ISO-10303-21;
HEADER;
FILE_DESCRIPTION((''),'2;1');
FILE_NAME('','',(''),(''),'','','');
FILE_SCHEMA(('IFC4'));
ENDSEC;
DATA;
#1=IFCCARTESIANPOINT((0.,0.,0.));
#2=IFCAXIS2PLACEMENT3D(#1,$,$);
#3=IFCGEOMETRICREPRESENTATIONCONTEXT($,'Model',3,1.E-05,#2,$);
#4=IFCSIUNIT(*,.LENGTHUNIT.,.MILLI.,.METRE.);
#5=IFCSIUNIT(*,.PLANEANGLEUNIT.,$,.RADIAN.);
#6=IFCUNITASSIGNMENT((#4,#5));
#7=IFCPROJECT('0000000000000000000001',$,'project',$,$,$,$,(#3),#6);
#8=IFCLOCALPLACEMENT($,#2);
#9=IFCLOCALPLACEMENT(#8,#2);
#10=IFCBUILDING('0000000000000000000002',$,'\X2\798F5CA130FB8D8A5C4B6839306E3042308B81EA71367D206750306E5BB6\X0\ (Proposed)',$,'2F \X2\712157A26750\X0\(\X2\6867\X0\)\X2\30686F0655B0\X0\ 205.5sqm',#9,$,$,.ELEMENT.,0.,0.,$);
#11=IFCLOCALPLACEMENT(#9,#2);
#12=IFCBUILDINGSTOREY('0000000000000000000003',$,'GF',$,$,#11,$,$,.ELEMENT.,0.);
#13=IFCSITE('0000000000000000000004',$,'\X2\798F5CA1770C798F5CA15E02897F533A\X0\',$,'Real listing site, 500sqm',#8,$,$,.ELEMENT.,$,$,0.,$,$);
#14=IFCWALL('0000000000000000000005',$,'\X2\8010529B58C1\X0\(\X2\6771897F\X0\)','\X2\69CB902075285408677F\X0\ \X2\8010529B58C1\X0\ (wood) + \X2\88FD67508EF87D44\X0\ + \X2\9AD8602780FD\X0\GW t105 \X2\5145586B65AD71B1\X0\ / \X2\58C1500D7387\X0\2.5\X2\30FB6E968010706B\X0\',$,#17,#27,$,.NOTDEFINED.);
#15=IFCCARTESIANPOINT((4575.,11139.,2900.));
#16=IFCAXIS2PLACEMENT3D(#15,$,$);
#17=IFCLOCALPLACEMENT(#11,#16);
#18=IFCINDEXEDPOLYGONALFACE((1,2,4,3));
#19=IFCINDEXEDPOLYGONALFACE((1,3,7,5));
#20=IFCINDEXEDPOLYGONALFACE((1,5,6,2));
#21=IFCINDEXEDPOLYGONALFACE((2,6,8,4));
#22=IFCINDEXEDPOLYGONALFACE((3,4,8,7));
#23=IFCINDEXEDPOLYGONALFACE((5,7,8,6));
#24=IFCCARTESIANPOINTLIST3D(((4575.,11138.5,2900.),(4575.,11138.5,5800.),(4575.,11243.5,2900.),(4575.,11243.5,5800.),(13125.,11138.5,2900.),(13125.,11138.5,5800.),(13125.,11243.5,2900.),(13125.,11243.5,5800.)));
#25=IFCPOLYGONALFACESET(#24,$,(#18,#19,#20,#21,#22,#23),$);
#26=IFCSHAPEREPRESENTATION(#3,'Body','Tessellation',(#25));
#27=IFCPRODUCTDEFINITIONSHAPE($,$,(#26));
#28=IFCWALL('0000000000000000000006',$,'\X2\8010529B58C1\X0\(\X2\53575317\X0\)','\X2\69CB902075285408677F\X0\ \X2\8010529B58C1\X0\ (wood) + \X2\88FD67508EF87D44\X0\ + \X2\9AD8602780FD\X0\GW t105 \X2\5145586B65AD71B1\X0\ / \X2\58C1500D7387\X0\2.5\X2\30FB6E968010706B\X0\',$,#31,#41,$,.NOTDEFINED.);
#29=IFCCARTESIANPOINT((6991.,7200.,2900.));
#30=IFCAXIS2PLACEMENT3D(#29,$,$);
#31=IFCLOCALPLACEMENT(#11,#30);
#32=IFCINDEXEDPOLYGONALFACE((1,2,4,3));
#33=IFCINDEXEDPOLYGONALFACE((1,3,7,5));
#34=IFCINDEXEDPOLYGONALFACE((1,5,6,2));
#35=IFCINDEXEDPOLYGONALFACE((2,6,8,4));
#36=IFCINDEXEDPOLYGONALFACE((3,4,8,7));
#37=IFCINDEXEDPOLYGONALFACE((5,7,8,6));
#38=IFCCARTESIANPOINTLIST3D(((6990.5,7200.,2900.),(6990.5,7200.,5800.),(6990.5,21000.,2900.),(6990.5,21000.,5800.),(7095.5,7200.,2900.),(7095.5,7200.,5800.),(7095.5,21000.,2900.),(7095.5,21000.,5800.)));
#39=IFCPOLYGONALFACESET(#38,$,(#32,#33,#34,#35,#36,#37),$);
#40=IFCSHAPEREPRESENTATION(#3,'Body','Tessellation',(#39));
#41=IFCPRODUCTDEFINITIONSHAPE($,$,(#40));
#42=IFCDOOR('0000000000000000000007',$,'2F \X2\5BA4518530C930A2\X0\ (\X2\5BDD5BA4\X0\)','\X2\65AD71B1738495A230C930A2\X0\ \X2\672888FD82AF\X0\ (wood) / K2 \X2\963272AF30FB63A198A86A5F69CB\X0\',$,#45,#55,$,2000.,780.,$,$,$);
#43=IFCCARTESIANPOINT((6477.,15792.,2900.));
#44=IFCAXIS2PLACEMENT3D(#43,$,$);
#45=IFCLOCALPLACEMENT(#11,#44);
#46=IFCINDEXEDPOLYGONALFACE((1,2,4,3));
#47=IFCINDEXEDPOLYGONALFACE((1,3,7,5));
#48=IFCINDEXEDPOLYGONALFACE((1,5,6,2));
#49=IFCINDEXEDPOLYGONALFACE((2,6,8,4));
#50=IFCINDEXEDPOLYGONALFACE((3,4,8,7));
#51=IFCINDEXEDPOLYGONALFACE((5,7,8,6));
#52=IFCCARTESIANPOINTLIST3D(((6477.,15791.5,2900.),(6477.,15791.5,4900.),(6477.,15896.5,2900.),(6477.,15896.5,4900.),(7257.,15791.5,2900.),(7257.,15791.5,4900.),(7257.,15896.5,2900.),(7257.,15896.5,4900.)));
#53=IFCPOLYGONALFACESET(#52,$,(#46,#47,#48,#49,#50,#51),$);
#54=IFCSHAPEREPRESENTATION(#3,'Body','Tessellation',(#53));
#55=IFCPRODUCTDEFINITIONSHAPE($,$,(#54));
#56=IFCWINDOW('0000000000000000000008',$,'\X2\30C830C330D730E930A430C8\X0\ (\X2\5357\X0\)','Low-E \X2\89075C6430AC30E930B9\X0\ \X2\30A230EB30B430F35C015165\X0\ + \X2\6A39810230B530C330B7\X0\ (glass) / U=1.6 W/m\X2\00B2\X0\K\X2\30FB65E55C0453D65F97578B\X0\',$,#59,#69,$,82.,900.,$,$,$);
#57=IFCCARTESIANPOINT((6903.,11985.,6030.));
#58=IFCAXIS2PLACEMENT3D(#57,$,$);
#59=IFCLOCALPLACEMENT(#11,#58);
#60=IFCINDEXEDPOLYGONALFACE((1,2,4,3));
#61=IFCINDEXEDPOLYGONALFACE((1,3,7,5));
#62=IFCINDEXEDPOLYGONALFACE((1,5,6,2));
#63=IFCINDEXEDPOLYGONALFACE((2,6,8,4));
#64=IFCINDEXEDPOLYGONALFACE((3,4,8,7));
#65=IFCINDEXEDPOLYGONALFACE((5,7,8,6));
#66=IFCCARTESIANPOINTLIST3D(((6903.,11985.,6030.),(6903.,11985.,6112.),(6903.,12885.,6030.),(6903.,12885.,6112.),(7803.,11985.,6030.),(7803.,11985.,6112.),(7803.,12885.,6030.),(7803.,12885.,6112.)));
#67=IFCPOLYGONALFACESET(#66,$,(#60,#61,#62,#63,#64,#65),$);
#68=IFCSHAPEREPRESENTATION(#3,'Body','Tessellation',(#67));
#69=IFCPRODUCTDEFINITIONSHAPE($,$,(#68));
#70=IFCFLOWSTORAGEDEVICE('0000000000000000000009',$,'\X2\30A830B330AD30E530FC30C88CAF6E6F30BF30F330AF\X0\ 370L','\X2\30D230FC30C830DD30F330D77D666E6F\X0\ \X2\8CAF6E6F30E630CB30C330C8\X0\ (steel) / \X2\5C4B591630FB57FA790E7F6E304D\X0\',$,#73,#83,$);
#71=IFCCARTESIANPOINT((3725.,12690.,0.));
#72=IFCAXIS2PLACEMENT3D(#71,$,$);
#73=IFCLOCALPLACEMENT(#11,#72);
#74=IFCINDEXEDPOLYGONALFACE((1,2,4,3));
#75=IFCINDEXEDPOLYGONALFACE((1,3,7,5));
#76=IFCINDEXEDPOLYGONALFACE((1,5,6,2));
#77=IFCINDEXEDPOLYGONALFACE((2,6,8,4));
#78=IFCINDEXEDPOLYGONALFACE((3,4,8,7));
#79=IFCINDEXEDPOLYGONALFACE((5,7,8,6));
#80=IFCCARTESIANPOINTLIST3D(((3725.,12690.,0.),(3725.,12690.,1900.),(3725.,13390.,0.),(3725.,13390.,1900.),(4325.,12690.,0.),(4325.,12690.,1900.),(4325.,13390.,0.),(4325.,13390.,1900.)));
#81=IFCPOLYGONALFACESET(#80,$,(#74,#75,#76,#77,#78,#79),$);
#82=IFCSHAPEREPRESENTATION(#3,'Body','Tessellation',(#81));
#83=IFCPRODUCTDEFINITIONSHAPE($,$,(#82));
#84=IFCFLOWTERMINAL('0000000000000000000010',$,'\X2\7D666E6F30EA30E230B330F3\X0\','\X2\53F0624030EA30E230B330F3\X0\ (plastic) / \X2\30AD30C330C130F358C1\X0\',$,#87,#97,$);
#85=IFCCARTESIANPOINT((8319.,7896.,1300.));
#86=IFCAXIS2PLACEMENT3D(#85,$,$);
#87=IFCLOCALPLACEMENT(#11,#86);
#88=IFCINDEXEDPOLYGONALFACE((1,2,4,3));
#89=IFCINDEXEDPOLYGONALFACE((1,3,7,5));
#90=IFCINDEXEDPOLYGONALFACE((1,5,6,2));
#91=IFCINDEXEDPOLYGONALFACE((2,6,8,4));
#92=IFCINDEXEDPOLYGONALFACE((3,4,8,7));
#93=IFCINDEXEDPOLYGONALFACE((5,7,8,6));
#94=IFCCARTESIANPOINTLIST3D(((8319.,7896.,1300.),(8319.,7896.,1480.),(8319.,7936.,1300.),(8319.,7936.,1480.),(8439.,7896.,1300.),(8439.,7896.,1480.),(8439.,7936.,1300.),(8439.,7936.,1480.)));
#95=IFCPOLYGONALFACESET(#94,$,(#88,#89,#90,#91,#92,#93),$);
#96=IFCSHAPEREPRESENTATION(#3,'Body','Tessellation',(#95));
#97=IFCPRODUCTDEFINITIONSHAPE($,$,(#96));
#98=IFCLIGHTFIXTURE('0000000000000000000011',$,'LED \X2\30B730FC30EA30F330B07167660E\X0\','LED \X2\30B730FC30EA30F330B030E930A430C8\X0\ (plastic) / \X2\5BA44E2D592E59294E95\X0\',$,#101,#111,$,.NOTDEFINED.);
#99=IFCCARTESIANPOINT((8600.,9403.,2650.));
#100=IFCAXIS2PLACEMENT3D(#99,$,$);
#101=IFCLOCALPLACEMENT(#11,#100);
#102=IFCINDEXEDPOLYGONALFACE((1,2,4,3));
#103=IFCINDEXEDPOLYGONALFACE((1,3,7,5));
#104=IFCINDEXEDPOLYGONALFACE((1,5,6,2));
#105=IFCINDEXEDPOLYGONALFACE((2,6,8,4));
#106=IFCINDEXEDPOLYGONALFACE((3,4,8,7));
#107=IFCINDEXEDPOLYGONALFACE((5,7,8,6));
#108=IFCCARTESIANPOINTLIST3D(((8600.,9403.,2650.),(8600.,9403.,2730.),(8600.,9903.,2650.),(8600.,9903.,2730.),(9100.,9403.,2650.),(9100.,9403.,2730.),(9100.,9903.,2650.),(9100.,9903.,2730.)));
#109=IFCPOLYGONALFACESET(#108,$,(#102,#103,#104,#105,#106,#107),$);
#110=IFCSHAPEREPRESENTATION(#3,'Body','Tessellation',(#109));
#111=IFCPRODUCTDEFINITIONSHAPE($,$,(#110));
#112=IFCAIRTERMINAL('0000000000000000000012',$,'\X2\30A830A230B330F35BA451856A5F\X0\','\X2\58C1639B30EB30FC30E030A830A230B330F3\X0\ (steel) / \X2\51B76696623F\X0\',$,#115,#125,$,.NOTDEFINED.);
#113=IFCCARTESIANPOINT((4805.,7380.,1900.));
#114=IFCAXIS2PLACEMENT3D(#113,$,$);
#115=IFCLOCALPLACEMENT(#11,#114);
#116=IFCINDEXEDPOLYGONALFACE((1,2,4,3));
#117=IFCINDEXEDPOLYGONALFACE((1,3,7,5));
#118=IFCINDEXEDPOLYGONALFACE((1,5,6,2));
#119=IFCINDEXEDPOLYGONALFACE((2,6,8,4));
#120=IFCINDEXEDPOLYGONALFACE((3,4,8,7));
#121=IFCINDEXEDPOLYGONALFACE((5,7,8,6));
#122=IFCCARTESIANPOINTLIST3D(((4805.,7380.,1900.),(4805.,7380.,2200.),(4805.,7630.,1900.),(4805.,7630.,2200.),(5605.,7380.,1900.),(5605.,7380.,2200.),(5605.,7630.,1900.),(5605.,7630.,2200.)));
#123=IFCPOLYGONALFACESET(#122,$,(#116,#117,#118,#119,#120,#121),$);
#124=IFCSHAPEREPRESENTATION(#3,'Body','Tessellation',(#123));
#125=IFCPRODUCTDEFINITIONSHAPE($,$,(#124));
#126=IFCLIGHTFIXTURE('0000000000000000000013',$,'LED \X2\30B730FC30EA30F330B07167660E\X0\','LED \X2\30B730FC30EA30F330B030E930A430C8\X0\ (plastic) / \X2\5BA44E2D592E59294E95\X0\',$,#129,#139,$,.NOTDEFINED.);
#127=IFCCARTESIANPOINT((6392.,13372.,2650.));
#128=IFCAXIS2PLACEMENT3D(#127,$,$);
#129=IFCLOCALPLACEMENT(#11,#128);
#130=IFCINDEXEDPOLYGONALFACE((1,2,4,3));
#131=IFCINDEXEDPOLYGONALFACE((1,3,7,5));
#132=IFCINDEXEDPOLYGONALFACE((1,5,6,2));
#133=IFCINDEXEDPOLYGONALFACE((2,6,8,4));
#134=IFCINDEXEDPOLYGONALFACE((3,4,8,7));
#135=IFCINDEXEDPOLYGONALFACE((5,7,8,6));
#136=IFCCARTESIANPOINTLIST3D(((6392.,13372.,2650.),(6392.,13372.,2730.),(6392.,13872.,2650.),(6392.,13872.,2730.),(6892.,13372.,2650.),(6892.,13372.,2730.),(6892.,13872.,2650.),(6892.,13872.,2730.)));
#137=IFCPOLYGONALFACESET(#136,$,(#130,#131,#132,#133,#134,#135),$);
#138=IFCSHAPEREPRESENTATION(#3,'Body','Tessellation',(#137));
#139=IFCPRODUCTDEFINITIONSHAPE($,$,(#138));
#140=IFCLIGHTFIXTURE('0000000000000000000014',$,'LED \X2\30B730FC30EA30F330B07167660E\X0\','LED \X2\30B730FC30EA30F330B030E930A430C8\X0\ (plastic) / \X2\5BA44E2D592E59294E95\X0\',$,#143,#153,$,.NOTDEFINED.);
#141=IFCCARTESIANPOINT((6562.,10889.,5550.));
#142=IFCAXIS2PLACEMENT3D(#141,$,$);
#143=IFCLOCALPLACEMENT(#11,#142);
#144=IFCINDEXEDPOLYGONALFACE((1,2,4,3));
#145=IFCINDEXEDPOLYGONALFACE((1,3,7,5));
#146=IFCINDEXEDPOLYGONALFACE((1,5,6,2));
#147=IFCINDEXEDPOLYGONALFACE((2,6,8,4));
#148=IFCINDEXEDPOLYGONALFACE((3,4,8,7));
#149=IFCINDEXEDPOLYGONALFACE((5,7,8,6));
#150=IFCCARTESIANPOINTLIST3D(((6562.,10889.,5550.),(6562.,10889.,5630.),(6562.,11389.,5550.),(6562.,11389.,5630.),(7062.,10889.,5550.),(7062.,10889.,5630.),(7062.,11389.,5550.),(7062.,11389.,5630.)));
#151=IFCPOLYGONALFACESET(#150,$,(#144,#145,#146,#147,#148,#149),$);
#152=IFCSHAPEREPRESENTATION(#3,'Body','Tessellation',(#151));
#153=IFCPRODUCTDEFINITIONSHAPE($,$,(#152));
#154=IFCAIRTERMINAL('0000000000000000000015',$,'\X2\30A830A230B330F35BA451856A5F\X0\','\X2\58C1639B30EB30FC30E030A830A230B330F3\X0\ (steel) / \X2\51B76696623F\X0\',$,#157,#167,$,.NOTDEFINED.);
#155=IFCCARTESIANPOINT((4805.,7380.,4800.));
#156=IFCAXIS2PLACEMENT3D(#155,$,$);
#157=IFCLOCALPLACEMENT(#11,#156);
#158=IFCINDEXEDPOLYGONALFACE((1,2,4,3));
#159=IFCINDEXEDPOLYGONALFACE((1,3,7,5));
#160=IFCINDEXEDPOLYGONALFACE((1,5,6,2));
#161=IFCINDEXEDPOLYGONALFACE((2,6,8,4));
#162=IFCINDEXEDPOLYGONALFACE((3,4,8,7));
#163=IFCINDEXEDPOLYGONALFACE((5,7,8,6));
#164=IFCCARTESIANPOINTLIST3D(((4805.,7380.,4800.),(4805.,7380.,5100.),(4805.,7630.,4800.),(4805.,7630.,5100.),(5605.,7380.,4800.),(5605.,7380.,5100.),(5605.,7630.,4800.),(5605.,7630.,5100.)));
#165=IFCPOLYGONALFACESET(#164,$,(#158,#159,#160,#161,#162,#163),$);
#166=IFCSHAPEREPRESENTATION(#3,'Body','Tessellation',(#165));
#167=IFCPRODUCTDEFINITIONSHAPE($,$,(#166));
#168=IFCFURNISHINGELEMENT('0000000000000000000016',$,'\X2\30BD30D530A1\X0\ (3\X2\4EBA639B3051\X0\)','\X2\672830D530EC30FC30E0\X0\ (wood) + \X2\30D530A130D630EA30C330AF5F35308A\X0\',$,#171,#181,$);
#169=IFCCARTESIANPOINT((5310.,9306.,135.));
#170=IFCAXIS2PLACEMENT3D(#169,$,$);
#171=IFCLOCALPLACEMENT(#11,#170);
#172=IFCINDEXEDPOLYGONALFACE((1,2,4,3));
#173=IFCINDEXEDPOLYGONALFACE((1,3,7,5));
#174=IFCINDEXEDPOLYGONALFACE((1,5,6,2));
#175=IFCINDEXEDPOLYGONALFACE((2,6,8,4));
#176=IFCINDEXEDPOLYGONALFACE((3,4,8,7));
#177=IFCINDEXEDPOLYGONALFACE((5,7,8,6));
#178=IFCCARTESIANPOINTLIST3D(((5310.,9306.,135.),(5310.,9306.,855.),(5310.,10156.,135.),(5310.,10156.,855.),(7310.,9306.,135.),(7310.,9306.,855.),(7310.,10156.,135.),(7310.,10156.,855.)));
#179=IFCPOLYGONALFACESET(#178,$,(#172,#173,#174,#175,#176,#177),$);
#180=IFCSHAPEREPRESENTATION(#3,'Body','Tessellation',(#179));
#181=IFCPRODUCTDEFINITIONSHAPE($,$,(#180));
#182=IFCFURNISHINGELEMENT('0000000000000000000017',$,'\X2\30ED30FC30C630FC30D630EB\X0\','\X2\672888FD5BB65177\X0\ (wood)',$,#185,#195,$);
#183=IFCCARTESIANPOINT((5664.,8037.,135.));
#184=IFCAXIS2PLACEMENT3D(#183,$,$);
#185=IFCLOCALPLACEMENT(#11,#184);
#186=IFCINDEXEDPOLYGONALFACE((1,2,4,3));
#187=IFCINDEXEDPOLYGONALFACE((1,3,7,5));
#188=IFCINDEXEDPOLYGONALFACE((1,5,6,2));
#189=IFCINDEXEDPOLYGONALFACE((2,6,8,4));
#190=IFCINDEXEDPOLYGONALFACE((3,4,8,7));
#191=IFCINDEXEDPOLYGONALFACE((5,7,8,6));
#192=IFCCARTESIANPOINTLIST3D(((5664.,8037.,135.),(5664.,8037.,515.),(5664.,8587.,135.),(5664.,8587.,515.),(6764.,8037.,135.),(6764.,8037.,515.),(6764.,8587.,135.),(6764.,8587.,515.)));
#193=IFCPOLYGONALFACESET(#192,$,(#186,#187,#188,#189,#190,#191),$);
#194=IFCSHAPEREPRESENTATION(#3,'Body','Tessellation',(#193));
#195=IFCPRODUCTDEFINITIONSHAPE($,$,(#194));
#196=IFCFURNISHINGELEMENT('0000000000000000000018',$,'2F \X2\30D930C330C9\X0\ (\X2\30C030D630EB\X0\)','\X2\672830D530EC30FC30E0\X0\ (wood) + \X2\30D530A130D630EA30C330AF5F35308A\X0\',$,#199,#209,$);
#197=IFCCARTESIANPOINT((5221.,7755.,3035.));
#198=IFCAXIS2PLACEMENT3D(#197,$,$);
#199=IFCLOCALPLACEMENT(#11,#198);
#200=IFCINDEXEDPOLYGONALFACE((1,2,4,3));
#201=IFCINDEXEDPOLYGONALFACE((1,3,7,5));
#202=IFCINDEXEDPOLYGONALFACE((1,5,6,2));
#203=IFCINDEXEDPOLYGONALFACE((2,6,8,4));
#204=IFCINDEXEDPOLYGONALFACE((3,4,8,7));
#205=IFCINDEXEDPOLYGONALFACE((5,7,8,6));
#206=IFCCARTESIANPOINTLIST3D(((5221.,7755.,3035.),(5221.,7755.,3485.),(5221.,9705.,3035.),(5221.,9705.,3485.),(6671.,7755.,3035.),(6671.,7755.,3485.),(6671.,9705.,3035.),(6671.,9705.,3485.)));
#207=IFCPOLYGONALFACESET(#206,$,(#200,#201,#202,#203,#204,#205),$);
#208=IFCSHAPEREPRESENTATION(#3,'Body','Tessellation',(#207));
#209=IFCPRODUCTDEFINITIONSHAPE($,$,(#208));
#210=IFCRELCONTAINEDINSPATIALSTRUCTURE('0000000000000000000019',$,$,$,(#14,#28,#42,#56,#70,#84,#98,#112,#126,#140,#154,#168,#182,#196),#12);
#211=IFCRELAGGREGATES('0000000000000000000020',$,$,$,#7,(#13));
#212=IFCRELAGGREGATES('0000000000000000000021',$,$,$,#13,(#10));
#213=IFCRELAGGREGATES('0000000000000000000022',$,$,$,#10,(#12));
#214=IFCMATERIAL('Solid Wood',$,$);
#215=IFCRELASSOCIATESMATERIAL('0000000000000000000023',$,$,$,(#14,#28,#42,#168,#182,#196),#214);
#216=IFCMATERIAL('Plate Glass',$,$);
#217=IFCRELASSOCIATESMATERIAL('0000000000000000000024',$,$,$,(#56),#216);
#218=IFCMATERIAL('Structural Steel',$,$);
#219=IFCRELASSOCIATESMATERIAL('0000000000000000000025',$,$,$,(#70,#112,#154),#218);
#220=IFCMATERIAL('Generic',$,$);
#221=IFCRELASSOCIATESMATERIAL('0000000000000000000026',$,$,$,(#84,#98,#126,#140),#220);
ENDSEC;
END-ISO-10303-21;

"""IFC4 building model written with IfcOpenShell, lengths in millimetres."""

from ifc_helpers import new_model, si_unit, frame, frame_2d, origin, place, context, project, spatial, rectangle, extrude, material, element, fill, save


model = new_model("IFC4")

# Units and contexts
model_context = context("Model", 3, precision=1e-05, world=origin())
ifc_project = project(units=[si_unit("LENGTHUNIT", "METRE", prefix="MILLI"), si_unit("PLANEANGLEUNIT", "RADIAN")], contexts=[model_context])

# Site, building, storey
site_placement = place(None, origin())
site = spatial("IfcSite", under=ifc_project, at=site_placement, Name="福岡県福岡市西区", ObjectType="Real listing site, 500sqm", CompositionType="ELEMENT", RefElevation=0.0)
building_placement = place(site_placement, origin())
building = spatial("IfcBuilding", under=site, at=building_placement, Name="福岡・越屋根のある自然素材の家 (Proposed)", ObjectType="2F 無垢材(桧)と漆喰 205.5sqm", CompositionType="ELEMENT", ElevationOfRefHeight=0.0, ElevationOfTerrain=0.0)
storey_placement = place(building_placement, origin())
storey = spatial("IfcBuildingStorey", under=building, at=storey_placement, Name="GF", CompositionType="ELEMENT", Elevation=0.0)

# Shared definitions
ifc_material_1 = material(Name="Solid Wood")

# Wall
wall_1_placement = place(storey_placement, frame((4575.0, 11139.0, 2900.0)))
element("IfcWall", 1, at=wall_1_placement, inside=storey, material=ifc_material_1, Name="耐力壁(東西)", Description="構造用合板 耐力壁 (wood) + 製材軸組 + 高性能GW t105 充填断熱 / 壁倍率2.5・準耐火", PredefinedType="NOTDEFINED", context=model_context, shape_type="SweptSolid", body=[
    extrude(rectangle(XDim=8550.0, YDim=105.0, at=frame_2d((4275.0, 52.0))), frame((4575.0, 11139.0, 2900.0)), (0.0, 0.0, 1.0), 2900.0),
])

# Wall, opening, door
wall_2_placement = place(storey_placement, frame((6991.0, 7200.0, 2900.0)))
wall_2 = element("IfcWall", 2, at=wall_2_placement, inside=storey, material=ifc_material_1, Name="耐力壁(南北)", Description="構造用合板 耐力壁 (wood) + 製材軸組 + 高性能GW t105 充填断熱 / 壁倍率2.5・準耐火", PredefinedType="NOTDEFINED", context=model_context, shape_type="SweptSolid", body=[
    extrude(rectangle(XDim=105.0, YDim=13800.0, at=frame_2d((52.0, 6900.0))), frame((6991.0, 7200.0, 2900.0)), (0.0, 0.0, 1.0), 2900.0),
])
opening_placement = place(storey_placement, frame((6477.0, 15792.0, 2900.0)))
opening = element("IfcOpeningElement", 3, at=opening_placement, cuts=wall_2, PredefinedType="NOTDEFINED", context=model_context, shape_type="SweptSolid", body=[
    extrude(rectangle(XDim=780.0, YDim=105.0, at=frame_2d((390.0, 52.0))), frame((6477.0, 15792.0, 2900.0)), (0.0, 0.0, 1.0), 2000.0),
])
door_placement = place(storey_placement, frame((6477.0, 15792.0, 2900.0)))
door = element("IfcDoor", 4, at=door_placement, inside=storey, material=ifc_material_1, Name="2F 室内ドア (寝室)", Description="断熱玄関ドア 木製芯 (wood) / K2 防犯・採風機構", OverallHeight=2000.0, OverallWidth=780.0, context=model_context, shape_type="SweptSolid", body=[
    extrude(rectangle(XDim=780.0, YDim=105.0, at=frame_2d((390.0, 52.0))), frame((6477.0, 15792.0, 2900.0)), (0.0, 0.0, 1.0), 2000.0),
])
fill(opening, door)

# Window
ifc_material_2 = material(Name="Plate Glass")
window_placement = place(storey_placement, frame((6903.0, 11985.0, 6030.0)))
element("IfcWindow", 5, at=window_placement, inside=storey, material=ifc_material_2, Name="トップライト (南)", Description="Low-E 複層ガラス アルゴン封入 + 樹脂サッシ (glass) / U=1.6 W/m²K・日射取得型", OverallHeight=82.0, OverallWidth=900.0, context=model_context, shape_type="SweptSolid", body=[
    extrude(rectangle(XDim=900.0, YDim=900.0, at=frame_2d((450.0, 450.0))), frame((6903.0, 11985.0, 6030.0)), (0.0, 0.0, 1.0), 82.0),
])

# Flow storage device
ifc_material_3 = material(Name="Structural Steel")
flow_storage_device_placement = place(storey_placement, frame((3725.0, 12690.0, 0.0)))
element("IfcFlowStorageDevice", 6, at=flow_storage_device_placement, inside=storey, material=ifc_material_3, Name="エコキュート貯湯タンク 370L", Description="ヒートポンプ給湯 貯湯ユニット (steel) / 屋外・基礎置き", context=model_context, shape_type="SweptSolid", body=[
    extrude(rectangle(XDim=600.0, YDim=700.0, at=frame_2d((300.0, 350.0))), frame((3725.0, 12690.0, 0.0)), (0.0, 0.0, 1.0), 1900.0),
])

# Flow terminal
ifc_material_4 = material(Name="Generic")
flow_terminal_placement = place(storey_placement, frame((8319.0, 7896.0, 1300.0)))
element("IfcFlowTerminal", 7, at=flow_terminal_placement, inside=storey, material=ifc_material_4, Name="給湯リモコン", Description="台所リモコン (plastic) / キッチン壁", context=model_context, shape_type="SweptSolid", body=[
    extrude(rectangle(XDim=120.0, YDim=40.0, at=frame_2d((60.0, 20.0))), frame((8319.0, 7896.0, 1300.0)), (0.0, 0.0, 1.0), 180.0),
])

# Light fixture
light_fixture_1_placement = place(storey_placement, frame((8600.0, 9403.0, 2650.0)))
element("IfcLightFixture", 8, at=light_fixture_1_placement, inside=storey, material=ifc_material_4, Name="LED シーリング照明", Description="LED シーリングライト (plastic) / 室中央天井", PredefinedType="NOTDEFINED", context=model_context, shape_type="SweptSolid", body=[
    extrude(rectangle(XDim=500.0, YDim=500.0, at=frame_2d((250.0, 250.0))), frame((8600.0, 9403.0, 2650.0)), (0.0, 0.0, 1.0), 80.0),
])

# Air terminal
air_terminal_1_placement = place(storey_placement, frame((4805.0, 7380.0, 1900.0)))
element("IfcAirTerminal", 9, at=air_terminal_1_placement, inside=storey, material=ifc_material_3, Name="エアコン室内機", Description="壁掛ルームエアコン (steel) / 冷暖房", PredefinedType="NOTDEFINED", context=model_context, shape_type="SweptSolid", body=[
    extrude(rectangle(XDim=800.0, YDim=250.0, at=frame_2d((400.0, 125.0))), frame((4805.0, 7380.0, 1900.0)), (0.0, 0.0, 1.0), 300.0),
])

# Light fixtures
light_fixture_2_placement = place(storey_placement, frame((6392.0, 13372.0, 2650.0)))
element("IfcLightFixture", 10, at=light_fixture_2_placement, inside=storey, material=ifc_material_4, Name="LED シーリング照明", Description="LED シーリングライト (plastic) / 室中央天井", PredefinedType="NOTDEFINED", context=model_context, shape_type="SweptSolid", body=[
    extrude(rectangle(XDim=500.0, YDim=500.0, at=frame_2d((250.0, 250.0))), frame((6392.0, 13372.0, 2650.0)), (0.0, 0.0, 1.0), 80.0),
])
light_fixture_3_placement = place(storey_placement, frame((6562.0, 10889.0, 5550.0)))
element("IfcLightFixture", 11, at=light_fixture_3_placement, inside=storey, material=ifc_material_4, Name="LED シーリング照明", Description="LED シーリングライト (plastic) / 室中央天井", PredefinedType="NOTDEFINED", context=model_context, shape_type="SweptSolid", body=[
    extrude(rectangle(XDim=500.0, YDim=500.0, at=frame_2d((250.0, 250.0))), frame((6562.0, 10889.0, 5550.0)), (0.0, 0.0, 1.0), 80.0),
])

# Air terminal
air_terminal_2_placement = place(storey_placement, frame((4805.0, 7380.0, 4800.0)))
element("IfcAirTerminal", 12, at=air_terminal_2_placement, inside=storey, material=ifc_material_3, Name="エアコン室内機", Description="壁掛ルームエアコン (steel) / 冷暖房", PredefinedType="NOTDEFINED", context=model_context, shape_type="SweptSolid", body=[
    extrude(rectangle(XDim=800.0, YDim=250.0, at=frame_2d((400.0, 125.0))), frame((4805.0, 7380.0, 4800.0)), (0.0, 0.0, 1.0), 300.0),
])

# Furnishing elements
furnishing_1_placement = place(storey_placement, frame((5310.0, 9306.0, 135.0)))
element("IfcFurnishingElement", 13, at=furnishing_1_placement, inside=storey, material=ifc_material_1, Name="ソファ (3人掛け)", Description="木フレーム (wood) + ファブリック張り", context=model_context, shape_type="SweptSolid", body=[
    extrude(rectangle(XDim=2000.0, YDim=850.0, at=frame_2d((1000.0, 425.0))), frame((5310.0, 9306.0, 135.0)), (0.0, 0.0, 1.0), 720.0),
])
furnishing_2_placement = place(storey_placement, frame((5664.0, 8037.0, 135.0)))
element("IfcFurnishingElement", 14, at=furnishing_2_placement, inside=storey, material=ifc_material_1, Name="ローテーブル", Description="木製家具 (wood)", context=model_context, shape_type="SweptSolid", body=[
    extrude(rectangle(XDim=1100.0, YDim=550.0, at=frame_2d((550.0, 275.0))), frame((5664.0, 8037.0, 135.0)), (0.0, 0.0, 1.0), 380.0),
])
furnishing_3_placement = place(storey_placement, frame((5221.0, 7755.0, 3035.0)))
element("IfcFurnishingElement", 15, at=furnishing_3_placement, inside=storey, material=ifc_material_1, Name="2F ベッド (ダブル)", Description="木フレーム (wood) + ファブリック張り", context=model_context, shape_type="SweptSolid", body=[
    extrude(rectangle(XDim=1450.0, YDim=1950.0, at=frame_2d((725.0, 975.0))), frame((5221.0, 7755.0, 3035.0)), (0.0, 0.0, 1.0), 450.0),
])

save(model, "model.ifc")
